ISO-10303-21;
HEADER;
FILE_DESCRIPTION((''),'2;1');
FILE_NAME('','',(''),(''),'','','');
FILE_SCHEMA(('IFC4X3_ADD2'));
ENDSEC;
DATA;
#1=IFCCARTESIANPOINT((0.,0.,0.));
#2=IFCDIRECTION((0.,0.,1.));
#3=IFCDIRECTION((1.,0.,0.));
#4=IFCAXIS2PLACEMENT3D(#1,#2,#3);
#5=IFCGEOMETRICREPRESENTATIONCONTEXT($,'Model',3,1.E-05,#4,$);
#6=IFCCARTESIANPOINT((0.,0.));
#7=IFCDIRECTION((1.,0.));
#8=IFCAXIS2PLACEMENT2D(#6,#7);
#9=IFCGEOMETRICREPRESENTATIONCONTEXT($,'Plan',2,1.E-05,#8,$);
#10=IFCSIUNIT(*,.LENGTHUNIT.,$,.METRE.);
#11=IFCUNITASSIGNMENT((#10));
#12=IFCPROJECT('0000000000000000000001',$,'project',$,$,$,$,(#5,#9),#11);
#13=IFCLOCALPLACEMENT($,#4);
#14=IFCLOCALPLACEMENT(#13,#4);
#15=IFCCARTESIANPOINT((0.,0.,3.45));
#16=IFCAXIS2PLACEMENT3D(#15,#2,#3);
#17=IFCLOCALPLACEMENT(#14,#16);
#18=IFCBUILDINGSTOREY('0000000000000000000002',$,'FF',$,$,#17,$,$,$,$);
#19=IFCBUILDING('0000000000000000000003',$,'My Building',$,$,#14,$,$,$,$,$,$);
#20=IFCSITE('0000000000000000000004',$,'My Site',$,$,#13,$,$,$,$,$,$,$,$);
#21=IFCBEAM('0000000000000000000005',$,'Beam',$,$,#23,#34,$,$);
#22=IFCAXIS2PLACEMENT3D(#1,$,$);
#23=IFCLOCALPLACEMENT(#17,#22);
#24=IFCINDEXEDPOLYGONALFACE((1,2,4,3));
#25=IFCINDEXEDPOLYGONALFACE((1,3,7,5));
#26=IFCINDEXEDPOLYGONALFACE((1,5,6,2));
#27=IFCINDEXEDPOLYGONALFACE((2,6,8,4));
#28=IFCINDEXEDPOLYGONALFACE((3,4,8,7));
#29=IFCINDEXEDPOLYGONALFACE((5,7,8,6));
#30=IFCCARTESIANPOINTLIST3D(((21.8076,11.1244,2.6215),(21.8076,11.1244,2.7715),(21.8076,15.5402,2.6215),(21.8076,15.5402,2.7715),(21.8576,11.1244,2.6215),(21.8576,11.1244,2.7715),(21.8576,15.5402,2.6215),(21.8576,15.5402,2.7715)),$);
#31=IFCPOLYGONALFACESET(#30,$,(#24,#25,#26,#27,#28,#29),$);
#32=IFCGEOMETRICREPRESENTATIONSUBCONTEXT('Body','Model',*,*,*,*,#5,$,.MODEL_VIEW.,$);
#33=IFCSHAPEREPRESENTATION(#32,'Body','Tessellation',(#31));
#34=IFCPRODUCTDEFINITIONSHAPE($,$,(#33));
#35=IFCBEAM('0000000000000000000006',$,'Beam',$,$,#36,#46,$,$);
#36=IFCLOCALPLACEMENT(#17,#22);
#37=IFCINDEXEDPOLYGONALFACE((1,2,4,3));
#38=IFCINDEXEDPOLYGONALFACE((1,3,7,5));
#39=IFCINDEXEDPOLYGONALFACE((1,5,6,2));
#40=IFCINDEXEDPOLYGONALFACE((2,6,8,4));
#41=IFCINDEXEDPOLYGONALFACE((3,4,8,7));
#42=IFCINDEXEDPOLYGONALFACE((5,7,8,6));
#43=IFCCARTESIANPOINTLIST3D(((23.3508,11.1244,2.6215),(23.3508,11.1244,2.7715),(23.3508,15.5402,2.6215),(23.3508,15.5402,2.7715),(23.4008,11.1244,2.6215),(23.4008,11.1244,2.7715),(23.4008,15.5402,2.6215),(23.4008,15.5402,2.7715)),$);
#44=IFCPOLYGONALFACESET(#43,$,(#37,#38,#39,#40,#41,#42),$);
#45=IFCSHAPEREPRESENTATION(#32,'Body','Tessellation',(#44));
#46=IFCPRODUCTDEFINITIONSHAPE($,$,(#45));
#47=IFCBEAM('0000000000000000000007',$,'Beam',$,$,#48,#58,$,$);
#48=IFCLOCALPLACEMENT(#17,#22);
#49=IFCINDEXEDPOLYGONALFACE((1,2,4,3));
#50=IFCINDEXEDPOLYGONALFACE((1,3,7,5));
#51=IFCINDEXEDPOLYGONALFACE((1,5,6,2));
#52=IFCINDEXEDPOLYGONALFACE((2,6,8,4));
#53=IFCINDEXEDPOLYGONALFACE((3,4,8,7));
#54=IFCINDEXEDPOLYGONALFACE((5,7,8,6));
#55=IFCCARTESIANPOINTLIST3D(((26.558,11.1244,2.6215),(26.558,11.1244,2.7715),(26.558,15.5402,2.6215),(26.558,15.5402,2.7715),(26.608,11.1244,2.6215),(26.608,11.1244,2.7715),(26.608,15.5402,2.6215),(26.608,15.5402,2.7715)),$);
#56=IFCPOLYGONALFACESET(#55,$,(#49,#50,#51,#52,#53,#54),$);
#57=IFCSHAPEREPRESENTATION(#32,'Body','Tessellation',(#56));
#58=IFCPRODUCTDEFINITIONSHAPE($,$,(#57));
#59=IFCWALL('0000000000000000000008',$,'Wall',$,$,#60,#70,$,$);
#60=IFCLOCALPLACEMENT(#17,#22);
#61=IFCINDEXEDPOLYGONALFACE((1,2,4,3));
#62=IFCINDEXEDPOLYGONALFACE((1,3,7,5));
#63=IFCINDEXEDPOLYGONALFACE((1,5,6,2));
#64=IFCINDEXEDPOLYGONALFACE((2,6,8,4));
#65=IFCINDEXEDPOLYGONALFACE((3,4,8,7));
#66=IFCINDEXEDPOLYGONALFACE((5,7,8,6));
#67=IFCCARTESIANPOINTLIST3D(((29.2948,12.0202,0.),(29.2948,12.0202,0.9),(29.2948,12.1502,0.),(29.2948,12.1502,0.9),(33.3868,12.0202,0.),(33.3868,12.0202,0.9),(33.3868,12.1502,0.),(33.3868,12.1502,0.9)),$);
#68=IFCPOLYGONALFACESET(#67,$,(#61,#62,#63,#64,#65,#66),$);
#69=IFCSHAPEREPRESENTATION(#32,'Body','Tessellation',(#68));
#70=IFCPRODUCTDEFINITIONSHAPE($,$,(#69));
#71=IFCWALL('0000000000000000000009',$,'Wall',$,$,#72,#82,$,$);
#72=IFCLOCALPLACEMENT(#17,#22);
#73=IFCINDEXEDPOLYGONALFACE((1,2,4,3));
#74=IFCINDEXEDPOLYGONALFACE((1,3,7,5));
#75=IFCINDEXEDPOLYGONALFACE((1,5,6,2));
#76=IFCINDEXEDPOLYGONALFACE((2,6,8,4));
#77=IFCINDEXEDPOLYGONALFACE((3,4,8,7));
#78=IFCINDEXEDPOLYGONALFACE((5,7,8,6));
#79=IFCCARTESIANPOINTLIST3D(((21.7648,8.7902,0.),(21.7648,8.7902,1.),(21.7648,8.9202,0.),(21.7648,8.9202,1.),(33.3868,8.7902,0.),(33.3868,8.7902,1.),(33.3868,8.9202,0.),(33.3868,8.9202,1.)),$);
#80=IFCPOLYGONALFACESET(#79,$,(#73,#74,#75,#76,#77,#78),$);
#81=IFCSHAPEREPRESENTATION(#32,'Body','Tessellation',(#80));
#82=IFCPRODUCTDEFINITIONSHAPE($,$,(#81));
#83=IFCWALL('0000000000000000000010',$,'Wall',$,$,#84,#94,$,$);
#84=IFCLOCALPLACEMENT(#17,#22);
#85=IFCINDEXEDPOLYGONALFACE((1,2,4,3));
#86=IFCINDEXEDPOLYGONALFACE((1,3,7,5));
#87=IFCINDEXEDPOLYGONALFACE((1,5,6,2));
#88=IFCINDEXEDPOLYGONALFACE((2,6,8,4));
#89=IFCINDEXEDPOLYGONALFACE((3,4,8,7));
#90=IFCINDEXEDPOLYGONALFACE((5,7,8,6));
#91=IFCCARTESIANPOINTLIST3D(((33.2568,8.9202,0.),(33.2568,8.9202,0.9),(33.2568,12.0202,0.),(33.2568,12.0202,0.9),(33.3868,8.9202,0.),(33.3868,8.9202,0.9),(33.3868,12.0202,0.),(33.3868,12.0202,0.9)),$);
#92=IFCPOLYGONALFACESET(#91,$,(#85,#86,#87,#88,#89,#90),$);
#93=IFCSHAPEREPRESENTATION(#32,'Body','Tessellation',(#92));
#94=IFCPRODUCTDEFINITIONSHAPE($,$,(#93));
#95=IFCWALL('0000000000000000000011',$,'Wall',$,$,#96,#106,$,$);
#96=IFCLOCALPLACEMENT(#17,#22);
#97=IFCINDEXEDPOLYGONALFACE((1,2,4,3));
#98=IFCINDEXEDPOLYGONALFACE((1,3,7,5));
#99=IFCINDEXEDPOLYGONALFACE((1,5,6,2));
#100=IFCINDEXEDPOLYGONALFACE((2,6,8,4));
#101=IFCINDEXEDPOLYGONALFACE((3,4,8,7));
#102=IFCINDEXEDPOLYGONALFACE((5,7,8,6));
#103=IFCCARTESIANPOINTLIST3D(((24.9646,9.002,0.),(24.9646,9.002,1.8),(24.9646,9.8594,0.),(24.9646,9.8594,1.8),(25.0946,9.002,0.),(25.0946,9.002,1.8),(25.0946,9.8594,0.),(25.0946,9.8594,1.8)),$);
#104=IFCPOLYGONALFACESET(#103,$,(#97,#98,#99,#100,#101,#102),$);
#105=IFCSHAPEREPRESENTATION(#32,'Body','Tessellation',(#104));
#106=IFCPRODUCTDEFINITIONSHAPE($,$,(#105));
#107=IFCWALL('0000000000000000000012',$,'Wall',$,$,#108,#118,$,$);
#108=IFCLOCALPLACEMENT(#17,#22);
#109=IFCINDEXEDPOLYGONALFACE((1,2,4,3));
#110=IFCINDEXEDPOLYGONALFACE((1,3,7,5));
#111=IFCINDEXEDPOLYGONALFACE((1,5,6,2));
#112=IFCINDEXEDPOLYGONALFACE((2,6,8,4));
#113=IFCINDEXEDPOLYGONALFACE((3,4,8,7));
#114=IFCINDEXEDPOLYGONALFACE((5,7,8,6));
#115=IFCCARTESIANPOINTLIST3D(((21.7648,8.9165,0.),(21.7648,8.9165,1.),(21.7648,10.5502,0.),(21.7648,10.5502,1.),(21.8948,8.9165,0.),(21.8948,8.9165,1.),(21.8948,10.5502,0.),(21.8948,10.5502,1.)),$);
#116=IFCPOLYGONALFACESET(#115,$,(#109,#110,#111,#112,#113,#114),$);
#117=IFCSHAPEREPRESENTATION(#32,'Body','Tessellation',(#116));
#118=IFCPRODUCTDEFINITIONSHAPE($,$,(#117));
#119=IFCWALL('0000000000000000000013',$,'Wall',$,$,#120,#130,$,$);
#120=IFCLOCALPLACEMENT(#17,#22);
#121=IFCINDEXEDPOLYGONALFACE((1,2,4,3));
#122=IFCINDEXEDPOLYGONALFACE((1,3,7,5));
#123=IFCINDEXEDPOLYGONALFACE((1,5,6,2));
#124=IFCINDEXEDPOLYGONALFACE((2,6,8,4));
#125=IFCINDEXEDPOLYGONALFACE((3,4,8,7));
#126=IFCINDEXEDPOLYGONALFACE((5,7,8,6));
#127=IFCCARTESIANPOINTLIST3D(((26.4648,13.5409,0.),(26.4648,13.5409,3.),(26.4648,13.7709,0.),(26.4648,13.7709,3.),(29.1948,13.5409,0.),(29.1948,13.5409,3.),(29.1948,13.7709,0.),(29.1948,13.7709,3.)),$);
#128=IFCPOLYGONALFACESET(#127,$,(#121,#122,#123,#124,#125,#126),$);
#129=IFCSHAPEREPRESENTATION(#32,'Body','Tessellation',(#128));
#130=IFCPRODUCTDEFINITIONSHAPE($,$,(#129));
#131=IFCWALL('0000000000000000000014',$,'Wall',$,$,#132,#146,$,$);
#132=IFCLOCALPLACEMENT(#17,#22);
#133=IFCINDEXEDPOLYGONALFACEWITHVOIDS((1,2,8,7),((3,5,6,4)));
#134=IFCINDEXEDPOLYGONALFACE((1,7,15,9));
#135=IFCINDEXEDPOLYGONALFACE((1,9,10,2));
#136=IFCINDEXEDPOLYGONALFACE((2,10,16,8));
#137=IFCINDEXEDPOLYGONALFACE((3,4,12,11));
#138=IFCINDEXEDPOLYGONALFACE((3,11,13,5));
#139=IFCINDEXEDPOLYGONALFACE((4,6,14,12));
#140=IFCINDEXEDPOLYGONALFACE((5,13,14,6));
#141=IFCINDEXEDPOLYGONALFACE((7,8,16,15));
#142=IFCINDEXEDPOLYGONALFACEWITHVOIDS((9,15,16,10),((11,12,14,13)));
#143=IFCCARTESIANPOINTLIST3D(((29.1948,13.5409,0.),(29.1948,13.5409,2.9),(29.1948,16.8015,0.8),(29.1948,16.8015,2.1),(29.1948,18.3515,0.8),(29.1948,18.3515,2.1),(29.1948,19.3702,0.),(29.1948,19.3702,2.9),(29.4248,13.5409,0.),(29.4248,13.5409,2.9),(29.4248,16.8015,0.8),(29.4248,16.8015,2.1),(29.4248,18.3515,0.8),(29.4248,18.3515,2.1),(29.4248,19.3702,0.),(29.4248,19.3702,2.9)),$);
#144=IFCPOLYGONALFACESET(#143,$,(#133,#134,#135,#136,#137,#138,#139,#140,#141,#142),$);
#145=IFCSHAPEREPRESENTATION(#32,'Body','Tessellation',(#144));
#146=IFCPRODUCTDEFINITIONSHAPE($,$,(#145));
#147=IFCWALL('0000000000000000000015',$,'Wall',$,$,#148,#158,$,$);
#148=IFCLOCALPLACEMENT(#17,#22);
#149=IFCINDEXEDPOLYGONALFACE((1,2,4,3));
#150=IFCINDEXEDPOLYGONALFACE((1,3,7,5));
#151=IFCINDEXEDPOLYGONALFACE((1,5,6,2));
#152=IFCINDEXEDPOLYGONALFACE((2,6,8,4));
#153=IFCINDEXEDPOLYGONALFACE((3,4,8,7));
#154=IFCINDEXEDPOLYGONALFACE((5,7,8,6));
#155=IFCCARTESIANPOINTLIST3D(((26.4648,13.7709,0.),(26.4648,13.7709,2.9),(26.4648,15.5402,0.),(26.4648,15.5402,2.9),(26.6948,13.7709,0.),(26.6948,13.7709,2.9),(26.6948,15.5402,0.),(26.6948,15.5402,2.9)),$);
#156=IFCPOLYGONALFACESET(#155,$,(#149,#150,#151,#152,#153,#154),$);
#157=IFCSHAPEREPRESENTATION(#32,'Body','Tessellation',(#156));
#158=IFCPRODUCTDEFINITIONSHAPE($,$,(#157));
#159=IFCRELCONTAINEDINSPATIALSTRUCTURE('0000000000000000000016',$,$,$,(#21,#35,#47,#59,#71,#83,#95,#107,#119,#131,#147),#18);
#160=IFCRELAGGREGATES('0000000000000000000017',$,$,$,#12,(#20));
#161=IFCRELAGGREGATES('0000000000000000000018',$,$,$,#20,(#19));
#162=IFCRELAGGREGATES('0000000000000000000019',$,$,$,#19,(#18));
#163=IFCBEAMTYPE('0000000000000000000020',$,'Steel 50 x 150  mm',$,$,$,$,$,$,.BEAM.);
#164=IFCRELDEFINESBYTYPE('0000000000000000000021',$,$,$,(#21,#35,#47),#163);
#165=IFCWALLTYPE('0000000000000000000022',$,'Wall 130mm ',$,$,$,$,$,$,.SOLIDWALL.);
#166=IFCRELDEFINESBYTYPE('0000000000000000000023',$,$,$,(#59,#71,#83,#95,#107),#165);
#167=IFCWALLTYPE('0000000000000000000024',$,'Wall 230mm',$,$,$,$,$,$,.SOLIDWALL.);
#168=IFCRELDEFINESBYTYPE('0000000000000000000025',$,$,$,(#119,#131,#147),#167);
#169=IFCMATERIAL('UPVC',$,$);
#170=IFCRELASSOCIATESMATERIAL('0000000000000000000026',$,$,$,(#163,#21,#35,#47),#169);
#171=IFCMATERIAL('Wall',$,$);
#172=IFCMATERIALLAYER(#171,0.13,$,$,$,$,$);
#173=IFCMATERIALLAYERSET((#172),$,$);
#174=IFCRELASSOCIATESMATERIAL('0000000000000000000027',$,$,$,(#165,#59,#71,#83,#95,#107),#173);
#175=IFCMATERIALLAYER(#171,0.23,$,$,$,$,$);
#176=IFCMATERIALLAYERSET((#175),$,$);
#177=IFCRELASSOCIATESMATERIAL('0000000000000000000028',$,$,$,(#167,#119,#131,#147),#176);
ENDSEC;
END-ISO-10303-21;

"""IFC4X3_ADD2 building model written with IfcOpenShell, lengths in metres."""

from ifc_helpers import new_model, si_unit, frame, origin_with_axes, origin_2d_with_axis, place, context, subcontext, project, spatial, line, indexed_curve, rectangle, outline, extrude, source, transform, mapped, material, layer, layer_set, layer_usage, material_profile, profile_set, profile_usage, type_object, element, save


model = new_model("IFC4X3_ADD2")

# Units and contexts
model_context = context("Model", 3, precision=1e-05, world=origin_with_axes())
plan_context = context("Plan", 2, precision=1e-05, world=origin_2d_with_axis())
body_context_1 = subcontext(model_context, "Body", "Model", "MODEL_VIEW")
ifc_project = project(units=[si_unit("LENGTHUNIT", "METRE")], contexts=[model_context, plan_context])

# Site, building, storey
site_placement = place(None, origin_with_axes())
site = spatial("IfcSite", under=ifc_project, at=site_placement, Name="My Site")
building_placement = place(site_placement, origin_with_axes())
building = spatial("IfcBuilding", under=site, at=building_placement, Name="My Building")
storey_placement = place(building_placement, frame((0.0, 0.0, 3.45), z_axis=(0.0, 0.0, 1.0), x_axis=(1.0, 0.0, 0.0)))
storey = spatial("IfcBuildingStorey", under=building, at=storey_placement, Name="FF")

# Beams
ifc_material_1 = material(Name="UPVC")
ifc_material_profile = material_profile(ifc_material_1, rectangle(XDim=0.05, YDim=0.15))
ifc_profile_set = profile_set([ifc_material_profile])
beam_type = type_object("IfcBeamType", Name="Steel 50 x 150  mm", PredefinedType="BEAM", material=ifc_profile_set)
ifc_profile_usage_1 = profile_usage(ifc_profile_set)
beam_1_placement = place(storey_placement, frame((21.8326, 11.1244, 2.6965), z_axis=(0.0, 1.0, 0.0), x_axis=(-1.0, 0.0, 0.0)))
element("IfcBeam", 1, at=beam_1_placement, inside=storey, type_object=beam_type, material=ifc_profile_usage_1, Name="Beam", context=body_context_1, shape_type="SweptSolid", body=[
    extrude(rectangle(XDim=0.05, YDim=0.15), origin_with_axes(), (0.0, 0.0, 1.0), 4.4158),
])
ifc_profile_usage_2 = profile_usage(ifc_profile_set)
beam_2_placement = place(storey_placement, frame((23.3758, 11.1244, 2.6965), z_axis=(0.0, 1.0, 0.0), x_axis=(-1.0, 0.0, 0.0)))
element("IfcBeam", 2, at=beam_2_placement, inside=storey, type_object=beam_type, material=ifc_profile_usage_2, Name="Beam", context=body_context_1, shape_type="SweptSolid", body=[
    extrude(rectangle(XDim=0.05, YDim=0.15), origin_with_axes(), (0.0, 0.0, 1.0), 4.4158),
])
ifc_profile_usage_3 = profile_usage(ifc_profile_set)
beam_3_placement = place(storey_placement, frame((26.583, 11.1244, 2.6965), z_axis=(0.0, 1.0, 0.0), x_axis=(-1.0, 0.0, 0.0)))
element("IfcBeam", 3, at=beam_3_placement, inside=storey, type_object=beam_type, material=ifc_profile_usage_3, Name="Beam", context=body_context_1, shape_type="SweptSolid", body=[
    extrude(rectangle(XDim=0.05, YDim=0.15), origin_with_axes(), (0.0, 0.0, 1.0), 4.4158),
])

# Walls
ifc_material_2 = material(Name="Wall")
ifc_layer_1 = layer(ifc_material_2, 0.13)
ifc_layer_set_1 = layer_set([ifc_layer_1])
ifc_layer_usage_1 = layer_usage(ifc_layer_set_1, "AXIS2", "POSITIVE", 0.0)
wall_type_1 = type_object("IfcWallType", Name="Wall 130mm ", PredefinedType="SOLIDWALL", material=ifc_layer_set_1)
wall_1_placement = place(storey_placement, frame((33.3868, 12.1502, 0.0), z_axis=(0.0, 0.0, 1.0), x_axis=(-1.0, 0.0, 0.0)))
element("IfcWall", 4, at=wall_1_placement, inside=storey, type_object=wall_type_1, material=ifc_layer_usage_1, Name="Wall", context=body_context_1, shape_type="SweptSolid", body=[
    extrude(outline(indexed_curve([(0.0, 0.0), (0.0, 0.13), (4.092, 0.13), (4.092, 0.0), (0.0, 0.0)], self_intersect=False)), origin_with_axes(), (0.0, 0.0, 1.0), 0.9),
])
ifc_layer_usage_2 = layer_usage(ifc_layer_set_1, "AXIS2", "POSITIVE", 0.0)
wall_2_placement = place(storey_placement, frame((33.3868, 8.9202, 0.0), z_axis=(0.0, 0.0, 1.0), x_axis=(-1.0, 0.0, 0.0)))
element("IfcWall", 5, at=wall_2_placement, inside=storey, type_object=wall_type_1, material=ifc_layer_usage_2, Name="Wall", context=body_context_1, shape_type="SweptSolid", body=[
    extrude(outline(indexed_curve([(0.0, 0.0), (0.0, 0.13), (11.622, 0.13), (11.622, 0.0), (0.0, 0.0)], self_intersect=False)), origin_with_axes(), (0.0, 0.0, 1.0), 1.0),
])
ifc_layer_usage_3 = layer_usage(ifc_layer_set_1, "AXIS2", "POSITIVE", 0.0)
wall_3_placement = place(storey_placement, frame((33.2568, 12.0202, 0.0), z_axis=(0.0, 0.0, 1.0), x_axis=(0.0, -1.0, 0.0)))
element("IfcWall", 6, at=wall_3_placement, inside=storey, type_object=wall_type_1, material=ifc_layer_usage_3, Name="Wall", context=body_context_1, shape_type="SweptSolid", body=[
    extrude(outline(indexed_curve([(0.0, 0.0), (0.0, 0.13), (3.1, 0.13), (3.1, 0.0), (0.0, 0.0)], self_intersect=False)), origin_with_axes(), (0.0, 0.0, 1.0), 0.9),
])
ifc_layer_usage_4 = layer_usage(ifc_layer_set_1, "AXIS2", "POSITIVE", 0.0)
wall_4_placement = place(storey_placement, frame((25.0946, 9.002, 0.0), z_axis=(0.0, 0.0, 1.0), x_axis=(0.0, 1.0, 0.0)))
element("IfcWall", 7, at=wall_4_placement, inside=storey, type_object=wall_type_1, material=ifc_layer_usage_4, Name="Wall", context=body_context_1, shape_type="SweptSolid", body=[
    extrude(outline(indexed_curve([(0.0, 0.0), (0.0, 0.13), (0.8574, 0.13), (0.8574, 0.0), (0.0, 0.0)], self_intersect=False)), origin_with_axes(), (0.0, 0.0, 1.0), 1.8),
])
ifc_layer_usage_5 = layer_usage(ifc_layer_set_1, "AXIS2", "POSITIVE", 0.0)
wall_5_placement = place(storey_placement, frame((21.7648, 10.5502, 0.0), z_axis=(0.0, 0.0, 1.0), x_axis=(0.0, -1.0, 0.0)))
element("IfcWall", 8, at=wall_5_placement, inside=storey, type_object=wall_type_1, material=ifc_layer_usage_5, Name="Wall", context=body_context_1, shape_type="SweptSolid", body=[
    extrude(outline(indexed_curve([(0.0, 0.0), (0.0, 0.13), (1.6337, 0.13), (1.6337, 0.0), (0.0, 0.0)], self_intersect=False)), origin_with_axes(), (0.0, 0.0, 1.0), 1.0),
])
ifc_layer_2 = layer(ifc_material_2, 0.23)
ifc_layer_set_2 = layer_set([ifc_layer_2])
ifc_layer_usage_6 = layer_usage(ifc_layer_set_2, "AXIS2", "POSITIVE", 0.0)
wall_type_2 = type_object("IfcWallType", Name="Wall 230mm", PredefinedType="SOLIDWALL", material=ifc_layer_set_2)
wall_6_placement = place(storey_placement, frame((29.1948, 13.7709, 0.0), z_axis=(0.0, 0.0, 1.0), x_axis=(-1.0, 0.0, 0.0)))
element("IfcWall", 9, at=wall_6_placement, inside=storey, type_object=wall_type_2, material=ifc_layer_usage_6, Name="Wall", context=body_context_1, shape_type="SweptSolid", body=[
    extrude(outline(indexed_curve([(0.0, 0.0), (0.0, 0.23), (2.73, 0.23), (2.73, 0.0), (0.0, 0.0)], self_intersect=False)), origin_with_axes(), (0.0, 0.0, 1.0), 3.0),
])

# Wall, opening
ifc_layer_usage_7 = layer_usage(ifc_layer_set_2, "AXIS2", "POSITIVE", 0.0)
wall_7_placement = place(storey_placement, frame((29.4248, 13.5409, 0.0), z_axis=(0.0, 0.0, 1.0), x_axis=(0.000001, 1.0, 0.0)))
wall_7 = element("IfcWall", 10, at=wall_7_placement, inside=storey, type_object=wall_type_2, material=ifc_layer_usage_7, Name="Wall", context=body_context_1, shape_type="SweptSolid", body=[
    extrude(outline(indexed_curve([(0.0, 0.0), (0.0, 0.23), (5.8293, 0.23), (5.8293, 0.0), (0.0, 0.0)], self_intersect=False)), origin_with_axes(), (0.0, 0.0, 1.0), 2.9),
])
shared_shape_1 = source(origin_with_axes(), body_context_1, "Body", "SweptSolid", [
    extrude(outline(indexed_curve([(0.0, 0.0), (1.55, 0.0), (1.55, 1.3), (0.0, 1.3)], segments=[line(1, 2, 3, 4, 1)])), frame((-0.775, -0.6, 0.0), z_axis=(0.0, -1.0, 0.0), x_axis=(1.0, 0.0, 0.0)), (0.0, 0.0, -1.0), 1.2),
])
opening_1_placement = place(wall_7_placement, frame((4.0356, 0.0, 0.8), z_axis=(0.0, 0.0, 1.0), x_axis=(1.0, 0.0, 0.0)))
element("IfcOpeningElement", 11, at=opening_1_placement, cuts=wall_7, PredefinedType="OPENING", context=body_context_1, shape_type="MappedRepresentation", body=[
    mapped(shared_shape_1, transform((0.0, 0.0, 0.0), x_axis=(1.0, 0.0, 0.0), y_axis=(0.0, 1.0, 0.0), z_axis=(0.0, 0.0, 1.0), scale=1.0)),
])

# Wall
ifc_layer_usage_8 = layer_usage(ifc_layer_set_2, "AXIS2", "POSITIVE", 0.0)
wall_8_placement = place(storey_placement, frame((26.6948, 13.7709, 0.0), z_axis=(0.0, 0.0, 1.0), x_axis=(0.000001, 1.0, 0.0)))
element("IfcWall", 12, at=wall_8_placement, inside=storey, type_object=wall_type_2, material=ifc_layer_usage_8, Name="Wall", context=body_context_1, shape_type="SweptSolid", body=[
    extrude(outline(indexed_curve([(0.0, 0.0), (0.0, 0.23), (1.7693, 0.23), (1.7693, 0.0), (0.0, 0.0)], self_intersect=False)), origin_with_axes(), (0.0, 0.0, 1.0), 2.9),
])

save(model, "model.ifc")
